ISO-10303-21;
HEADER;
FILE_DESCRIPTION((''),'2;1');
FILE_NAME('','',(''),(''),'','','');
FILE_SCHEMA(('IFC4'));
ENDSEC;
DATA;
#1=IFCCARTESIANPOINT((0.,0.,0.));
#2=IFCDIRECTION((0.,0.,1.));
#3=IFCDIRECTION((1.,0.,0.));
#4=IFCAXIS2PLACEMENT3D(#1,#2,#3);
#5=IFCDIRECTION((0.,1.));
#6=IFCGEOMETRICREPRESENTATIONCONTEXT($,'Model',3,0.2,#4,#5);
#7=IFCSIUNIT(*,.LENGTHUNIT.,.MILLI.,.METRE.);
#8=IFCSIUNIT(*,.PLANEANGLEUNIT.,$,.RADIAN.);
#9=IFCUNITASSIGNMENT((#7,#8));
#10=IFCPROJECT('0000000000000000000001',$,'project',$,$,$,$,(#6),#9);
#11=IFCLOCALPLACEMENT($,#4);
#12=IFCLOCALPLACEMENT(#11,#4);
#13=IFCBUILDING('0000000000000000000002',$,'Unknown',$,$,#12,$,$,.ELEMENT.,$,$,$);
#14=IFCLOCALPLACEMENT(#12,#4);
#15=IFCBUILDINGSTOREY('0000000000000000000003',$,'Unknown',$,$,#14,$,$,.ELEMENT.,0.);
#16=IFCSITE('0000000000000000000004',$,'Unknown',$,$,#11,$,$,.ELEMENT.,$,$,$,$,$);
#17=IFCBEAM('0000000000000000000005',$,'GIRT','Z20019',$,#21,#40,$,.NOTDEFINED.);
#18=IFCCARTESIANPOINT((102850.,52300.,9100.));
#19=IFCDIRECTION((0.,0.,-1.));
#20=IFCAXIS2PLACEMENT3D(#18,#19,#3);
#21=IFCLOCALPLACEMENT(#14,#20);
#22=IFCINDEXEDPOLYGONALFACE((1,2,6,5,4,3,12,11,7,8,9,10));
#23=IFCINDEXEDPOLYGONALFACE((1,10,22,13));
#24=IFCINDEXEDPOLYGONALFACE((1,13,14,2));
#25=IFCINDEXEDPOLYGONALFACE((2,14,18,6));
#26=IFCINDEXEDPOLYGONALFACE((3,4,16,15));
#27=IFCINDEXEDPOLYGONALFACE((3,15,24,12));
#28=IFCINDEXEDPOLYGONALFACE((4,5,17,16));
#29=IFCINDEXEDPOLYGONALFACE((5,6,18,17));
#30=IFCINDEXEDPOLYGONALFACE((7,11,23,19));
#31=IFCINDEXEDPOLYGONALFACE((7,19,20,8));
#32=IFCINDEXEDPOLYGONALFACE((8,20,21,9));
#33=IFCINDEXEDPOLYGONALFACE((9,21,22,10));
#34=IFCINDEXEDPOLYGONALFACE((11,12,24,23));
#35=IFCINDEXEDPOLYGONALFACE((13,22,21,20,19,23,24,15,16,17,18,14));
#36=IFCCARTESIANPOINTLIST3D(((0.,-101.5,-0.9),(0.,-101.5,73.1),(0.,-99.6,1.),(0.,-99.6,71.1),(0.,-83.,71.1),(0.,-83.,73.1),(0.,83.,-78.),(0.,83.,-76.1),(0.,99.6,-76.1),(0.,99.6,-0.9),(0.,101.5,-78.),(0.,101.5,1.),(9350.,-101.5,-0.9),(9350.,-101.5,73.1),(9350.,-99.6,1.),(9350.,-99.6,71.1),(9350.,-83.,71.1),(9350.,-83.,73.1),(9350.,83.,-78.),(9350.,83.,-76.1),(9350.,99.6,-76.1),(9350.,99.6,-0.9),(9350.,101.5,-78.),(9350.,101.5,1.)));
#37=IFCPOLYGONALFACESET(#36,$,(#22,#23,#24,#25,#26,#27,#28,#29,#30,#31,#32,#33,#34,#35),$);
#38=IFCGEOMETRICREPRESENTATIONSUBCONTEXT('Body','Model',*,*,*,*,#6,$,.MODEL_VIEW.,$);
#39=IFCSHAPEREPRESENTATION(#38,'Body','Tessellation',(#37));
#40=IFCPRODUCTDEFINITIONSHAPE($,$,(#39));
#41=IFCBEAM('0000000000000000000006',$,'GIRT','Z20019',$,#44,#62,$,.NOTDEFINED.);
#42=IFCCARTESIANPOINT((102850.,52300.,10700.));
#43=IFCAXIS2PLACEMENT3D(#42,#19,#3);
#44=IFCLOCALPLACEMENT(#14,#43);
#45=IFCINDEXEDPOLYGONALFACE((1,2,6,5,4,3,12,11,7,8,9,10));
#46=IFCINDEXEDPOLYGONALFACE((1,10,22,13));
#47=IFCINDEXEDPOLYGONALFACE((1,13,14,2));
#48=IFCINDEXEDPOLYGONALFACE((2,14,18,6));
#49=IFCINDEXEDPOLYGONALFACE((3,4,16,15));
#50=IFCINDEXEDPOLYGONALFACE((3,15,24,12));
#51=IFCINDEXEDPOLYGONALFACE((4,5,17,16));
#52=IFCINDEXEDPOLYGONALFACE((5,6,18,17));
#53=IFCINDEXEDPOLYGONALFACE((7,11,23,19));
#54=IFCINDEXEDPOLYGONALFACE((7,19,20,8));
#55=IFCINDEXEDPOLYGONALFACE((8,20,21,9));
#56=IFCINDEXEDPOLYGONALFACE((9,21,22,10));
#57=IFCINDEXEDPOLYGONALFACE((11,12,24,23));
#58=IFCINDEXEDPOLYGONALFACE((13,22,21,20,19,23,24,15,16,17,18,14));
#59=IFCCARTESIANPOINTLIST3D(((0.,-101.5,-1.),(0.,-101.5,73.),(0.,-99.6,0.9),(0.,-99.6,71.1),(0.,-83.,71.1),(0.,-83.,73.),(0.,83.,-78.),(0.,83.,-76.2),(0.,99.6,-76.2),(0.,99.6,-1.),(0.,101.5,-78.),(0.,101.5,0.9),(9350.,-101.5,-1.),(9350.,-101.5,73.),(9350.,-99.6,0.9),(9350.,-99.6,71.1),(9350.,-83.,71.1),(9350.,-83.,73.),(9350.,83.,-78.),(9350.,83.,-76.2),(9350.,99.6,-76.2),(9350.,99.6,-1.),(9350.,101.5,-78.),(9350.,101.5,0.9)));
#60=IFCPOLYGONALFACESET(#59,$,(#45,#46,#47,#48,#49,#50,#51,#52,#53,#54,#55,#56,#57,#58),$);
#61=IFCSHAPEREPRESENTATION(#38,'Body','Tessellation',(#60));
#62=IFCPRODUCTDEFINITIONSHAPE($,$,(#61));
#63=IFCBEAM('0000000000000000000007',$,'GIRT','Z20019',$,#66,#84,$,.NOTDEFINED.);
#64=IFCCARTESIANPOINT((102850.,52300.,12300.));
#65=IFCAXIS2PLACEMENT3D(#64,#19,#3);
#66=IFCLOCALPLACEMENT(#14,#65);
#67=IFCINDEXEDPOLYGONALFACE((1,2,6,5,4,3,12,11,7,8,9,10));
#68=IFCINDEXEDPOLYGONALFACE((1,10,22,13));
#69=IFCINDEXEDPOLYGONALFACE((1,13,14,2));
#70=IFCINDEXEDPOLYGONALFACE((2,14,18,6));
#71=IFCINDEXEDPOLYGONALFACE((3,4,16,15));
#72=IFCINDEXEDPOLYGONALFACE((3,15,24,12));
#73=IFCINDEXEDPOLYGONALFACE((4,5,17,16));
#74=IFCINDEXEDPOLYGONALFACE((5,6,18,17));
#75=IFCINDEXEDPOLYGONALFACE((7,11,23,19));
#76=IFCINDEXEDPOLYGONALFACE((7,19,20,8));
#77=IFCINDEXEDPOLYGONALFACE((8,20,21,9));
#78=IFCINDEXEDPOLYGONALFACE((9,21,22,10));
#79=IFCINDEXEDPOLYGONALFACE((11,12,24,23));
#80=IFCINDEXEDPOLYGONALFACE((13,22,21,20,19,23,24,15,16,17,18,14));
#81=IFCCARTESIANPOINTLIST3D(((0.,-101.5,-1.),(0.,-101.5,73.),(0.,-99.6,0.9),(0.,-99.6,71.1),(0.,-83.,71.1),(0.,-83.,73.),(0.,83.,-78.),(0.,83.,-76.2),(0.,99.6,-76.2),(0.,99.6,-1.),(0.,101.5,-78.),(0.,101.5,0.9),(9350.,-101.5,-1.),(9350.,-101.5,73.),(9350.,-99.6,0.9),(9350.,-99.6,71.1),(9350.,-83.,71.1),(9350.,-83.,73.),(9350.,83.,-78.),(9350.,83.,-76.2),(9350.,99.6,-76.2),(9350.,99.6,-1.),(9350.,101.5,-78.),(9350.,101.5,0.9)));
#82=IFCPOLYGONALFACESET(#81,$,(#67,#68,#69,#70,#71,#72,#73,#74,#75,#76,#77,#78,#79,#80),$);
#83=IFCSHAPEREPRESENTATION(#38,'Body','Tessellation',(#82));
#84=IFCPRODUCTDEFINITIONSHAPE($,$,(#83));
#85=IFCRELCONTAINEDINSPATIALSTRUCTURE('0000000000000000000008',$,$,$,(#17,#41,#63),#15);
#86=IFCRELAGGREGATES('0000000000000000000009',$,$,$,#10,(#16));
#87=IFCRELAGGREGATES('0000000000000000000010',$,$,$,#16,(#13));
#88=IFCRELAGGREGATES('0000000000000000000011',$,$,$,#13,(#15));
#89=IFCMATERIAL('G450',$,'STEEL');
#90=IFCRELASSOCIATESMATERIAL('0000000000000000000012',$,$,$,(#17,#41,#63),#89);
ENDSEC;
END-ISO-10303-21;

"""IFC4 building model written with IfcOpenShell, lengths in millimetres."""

from ifc_helpers import new_model, si_unit, direction, frame, origin_with_axes, place, context, subcontext, project, spatial, line, indexed_curve, outline, extrude, material, element, save


model = new_model("IFC4")

# Units and contexts
model_context = context("Model", 3, precision=0.2, world=origin_with_axes(), true_north=direction((0.0, 1.0)))
body_context = subcontext(model_context, "Body", "Model", "MODEL_VIEW")
ifc_project = project(units=[si_unit("LENGTHUNIT", "METRE", prefix="MILLI"), si_unit("PLANEANGLEUNIT", "RADIAN")], contexts=[model_context])

# Site, building, storey
site_placement = place(None, origin_with_axes())
site = spatial("IfcSite", under=ifc_project, at=site_placement, Name="Unknown", CompositionType="ELEMENT")
building_placement = place(site_placement, origin_with_axes())
building = spatial("IfcBuilding", under=site, at=building_placement, Name="Unknown", CompositionType="ELEMENT")
storey_placement = place(building_placement, origin_with_axes())
storey = spatial("IfcBuildingStorey", under=building, at=storey_placement, Name="Unknown", CompositionType="ELEMENT", Elevation=0.0)

# Shared definitions
ifc_material_1 = material(Name="G450", Category="STEEL")

# Beams
for number, where, z_axis, x_axis, name in (
    (1, (102850.0, 52300.0, 9100.0), (0.0, 0.0, -1.0), (1.0, 0.0, 0.0), "GIRT"),
    (2, (102850.0, 52300.0, 10700.0), (0.0, 0.0, -1.0), (1.0, 0.0, 0.0), "GIRT"),
    (3, (102850.0, 52300.0, 12300.0), (0.0, 0.0, -1.0), (1.0, 0.0, 0.0), "GIRT"),
):
    element("IfcBeam", number, at=place(storey_placement, frame(where, z_axis=z_axis, x_axis=x_axis)), inside=storey, material=ifc_material_1, Name=name, Description="Z20019", PredefinedType="NOTDEFINED", context=body_context, shape_type="SolidModel", body=[
        extrude(outline(indexed_curve([(73.0, -101.5), (73.0, -83.0), (71.2, -83.0), (71.2, -99.6), (0.9, -99.6), (0.9, 101.5), (-78.0, 101.5), (-78.0, 83.0), (-76.2, 83.0), (-76.2, 99.6), (-0.9, 99.6), (-0.9, -101.5)], segments=[line(1, 2, 3, 4, 5, 6, 7, 8, 9, 10, 11, 12, 1)])), frame((0.0, 0.0, 0.0), z_axis=(-1.0, 0.0, 0.0), x_axis=(0.0, 0.0, 1.0)), (0.0, 0.0, -1.0), 9350.0),
    ])

save(model, "model.ifc")
